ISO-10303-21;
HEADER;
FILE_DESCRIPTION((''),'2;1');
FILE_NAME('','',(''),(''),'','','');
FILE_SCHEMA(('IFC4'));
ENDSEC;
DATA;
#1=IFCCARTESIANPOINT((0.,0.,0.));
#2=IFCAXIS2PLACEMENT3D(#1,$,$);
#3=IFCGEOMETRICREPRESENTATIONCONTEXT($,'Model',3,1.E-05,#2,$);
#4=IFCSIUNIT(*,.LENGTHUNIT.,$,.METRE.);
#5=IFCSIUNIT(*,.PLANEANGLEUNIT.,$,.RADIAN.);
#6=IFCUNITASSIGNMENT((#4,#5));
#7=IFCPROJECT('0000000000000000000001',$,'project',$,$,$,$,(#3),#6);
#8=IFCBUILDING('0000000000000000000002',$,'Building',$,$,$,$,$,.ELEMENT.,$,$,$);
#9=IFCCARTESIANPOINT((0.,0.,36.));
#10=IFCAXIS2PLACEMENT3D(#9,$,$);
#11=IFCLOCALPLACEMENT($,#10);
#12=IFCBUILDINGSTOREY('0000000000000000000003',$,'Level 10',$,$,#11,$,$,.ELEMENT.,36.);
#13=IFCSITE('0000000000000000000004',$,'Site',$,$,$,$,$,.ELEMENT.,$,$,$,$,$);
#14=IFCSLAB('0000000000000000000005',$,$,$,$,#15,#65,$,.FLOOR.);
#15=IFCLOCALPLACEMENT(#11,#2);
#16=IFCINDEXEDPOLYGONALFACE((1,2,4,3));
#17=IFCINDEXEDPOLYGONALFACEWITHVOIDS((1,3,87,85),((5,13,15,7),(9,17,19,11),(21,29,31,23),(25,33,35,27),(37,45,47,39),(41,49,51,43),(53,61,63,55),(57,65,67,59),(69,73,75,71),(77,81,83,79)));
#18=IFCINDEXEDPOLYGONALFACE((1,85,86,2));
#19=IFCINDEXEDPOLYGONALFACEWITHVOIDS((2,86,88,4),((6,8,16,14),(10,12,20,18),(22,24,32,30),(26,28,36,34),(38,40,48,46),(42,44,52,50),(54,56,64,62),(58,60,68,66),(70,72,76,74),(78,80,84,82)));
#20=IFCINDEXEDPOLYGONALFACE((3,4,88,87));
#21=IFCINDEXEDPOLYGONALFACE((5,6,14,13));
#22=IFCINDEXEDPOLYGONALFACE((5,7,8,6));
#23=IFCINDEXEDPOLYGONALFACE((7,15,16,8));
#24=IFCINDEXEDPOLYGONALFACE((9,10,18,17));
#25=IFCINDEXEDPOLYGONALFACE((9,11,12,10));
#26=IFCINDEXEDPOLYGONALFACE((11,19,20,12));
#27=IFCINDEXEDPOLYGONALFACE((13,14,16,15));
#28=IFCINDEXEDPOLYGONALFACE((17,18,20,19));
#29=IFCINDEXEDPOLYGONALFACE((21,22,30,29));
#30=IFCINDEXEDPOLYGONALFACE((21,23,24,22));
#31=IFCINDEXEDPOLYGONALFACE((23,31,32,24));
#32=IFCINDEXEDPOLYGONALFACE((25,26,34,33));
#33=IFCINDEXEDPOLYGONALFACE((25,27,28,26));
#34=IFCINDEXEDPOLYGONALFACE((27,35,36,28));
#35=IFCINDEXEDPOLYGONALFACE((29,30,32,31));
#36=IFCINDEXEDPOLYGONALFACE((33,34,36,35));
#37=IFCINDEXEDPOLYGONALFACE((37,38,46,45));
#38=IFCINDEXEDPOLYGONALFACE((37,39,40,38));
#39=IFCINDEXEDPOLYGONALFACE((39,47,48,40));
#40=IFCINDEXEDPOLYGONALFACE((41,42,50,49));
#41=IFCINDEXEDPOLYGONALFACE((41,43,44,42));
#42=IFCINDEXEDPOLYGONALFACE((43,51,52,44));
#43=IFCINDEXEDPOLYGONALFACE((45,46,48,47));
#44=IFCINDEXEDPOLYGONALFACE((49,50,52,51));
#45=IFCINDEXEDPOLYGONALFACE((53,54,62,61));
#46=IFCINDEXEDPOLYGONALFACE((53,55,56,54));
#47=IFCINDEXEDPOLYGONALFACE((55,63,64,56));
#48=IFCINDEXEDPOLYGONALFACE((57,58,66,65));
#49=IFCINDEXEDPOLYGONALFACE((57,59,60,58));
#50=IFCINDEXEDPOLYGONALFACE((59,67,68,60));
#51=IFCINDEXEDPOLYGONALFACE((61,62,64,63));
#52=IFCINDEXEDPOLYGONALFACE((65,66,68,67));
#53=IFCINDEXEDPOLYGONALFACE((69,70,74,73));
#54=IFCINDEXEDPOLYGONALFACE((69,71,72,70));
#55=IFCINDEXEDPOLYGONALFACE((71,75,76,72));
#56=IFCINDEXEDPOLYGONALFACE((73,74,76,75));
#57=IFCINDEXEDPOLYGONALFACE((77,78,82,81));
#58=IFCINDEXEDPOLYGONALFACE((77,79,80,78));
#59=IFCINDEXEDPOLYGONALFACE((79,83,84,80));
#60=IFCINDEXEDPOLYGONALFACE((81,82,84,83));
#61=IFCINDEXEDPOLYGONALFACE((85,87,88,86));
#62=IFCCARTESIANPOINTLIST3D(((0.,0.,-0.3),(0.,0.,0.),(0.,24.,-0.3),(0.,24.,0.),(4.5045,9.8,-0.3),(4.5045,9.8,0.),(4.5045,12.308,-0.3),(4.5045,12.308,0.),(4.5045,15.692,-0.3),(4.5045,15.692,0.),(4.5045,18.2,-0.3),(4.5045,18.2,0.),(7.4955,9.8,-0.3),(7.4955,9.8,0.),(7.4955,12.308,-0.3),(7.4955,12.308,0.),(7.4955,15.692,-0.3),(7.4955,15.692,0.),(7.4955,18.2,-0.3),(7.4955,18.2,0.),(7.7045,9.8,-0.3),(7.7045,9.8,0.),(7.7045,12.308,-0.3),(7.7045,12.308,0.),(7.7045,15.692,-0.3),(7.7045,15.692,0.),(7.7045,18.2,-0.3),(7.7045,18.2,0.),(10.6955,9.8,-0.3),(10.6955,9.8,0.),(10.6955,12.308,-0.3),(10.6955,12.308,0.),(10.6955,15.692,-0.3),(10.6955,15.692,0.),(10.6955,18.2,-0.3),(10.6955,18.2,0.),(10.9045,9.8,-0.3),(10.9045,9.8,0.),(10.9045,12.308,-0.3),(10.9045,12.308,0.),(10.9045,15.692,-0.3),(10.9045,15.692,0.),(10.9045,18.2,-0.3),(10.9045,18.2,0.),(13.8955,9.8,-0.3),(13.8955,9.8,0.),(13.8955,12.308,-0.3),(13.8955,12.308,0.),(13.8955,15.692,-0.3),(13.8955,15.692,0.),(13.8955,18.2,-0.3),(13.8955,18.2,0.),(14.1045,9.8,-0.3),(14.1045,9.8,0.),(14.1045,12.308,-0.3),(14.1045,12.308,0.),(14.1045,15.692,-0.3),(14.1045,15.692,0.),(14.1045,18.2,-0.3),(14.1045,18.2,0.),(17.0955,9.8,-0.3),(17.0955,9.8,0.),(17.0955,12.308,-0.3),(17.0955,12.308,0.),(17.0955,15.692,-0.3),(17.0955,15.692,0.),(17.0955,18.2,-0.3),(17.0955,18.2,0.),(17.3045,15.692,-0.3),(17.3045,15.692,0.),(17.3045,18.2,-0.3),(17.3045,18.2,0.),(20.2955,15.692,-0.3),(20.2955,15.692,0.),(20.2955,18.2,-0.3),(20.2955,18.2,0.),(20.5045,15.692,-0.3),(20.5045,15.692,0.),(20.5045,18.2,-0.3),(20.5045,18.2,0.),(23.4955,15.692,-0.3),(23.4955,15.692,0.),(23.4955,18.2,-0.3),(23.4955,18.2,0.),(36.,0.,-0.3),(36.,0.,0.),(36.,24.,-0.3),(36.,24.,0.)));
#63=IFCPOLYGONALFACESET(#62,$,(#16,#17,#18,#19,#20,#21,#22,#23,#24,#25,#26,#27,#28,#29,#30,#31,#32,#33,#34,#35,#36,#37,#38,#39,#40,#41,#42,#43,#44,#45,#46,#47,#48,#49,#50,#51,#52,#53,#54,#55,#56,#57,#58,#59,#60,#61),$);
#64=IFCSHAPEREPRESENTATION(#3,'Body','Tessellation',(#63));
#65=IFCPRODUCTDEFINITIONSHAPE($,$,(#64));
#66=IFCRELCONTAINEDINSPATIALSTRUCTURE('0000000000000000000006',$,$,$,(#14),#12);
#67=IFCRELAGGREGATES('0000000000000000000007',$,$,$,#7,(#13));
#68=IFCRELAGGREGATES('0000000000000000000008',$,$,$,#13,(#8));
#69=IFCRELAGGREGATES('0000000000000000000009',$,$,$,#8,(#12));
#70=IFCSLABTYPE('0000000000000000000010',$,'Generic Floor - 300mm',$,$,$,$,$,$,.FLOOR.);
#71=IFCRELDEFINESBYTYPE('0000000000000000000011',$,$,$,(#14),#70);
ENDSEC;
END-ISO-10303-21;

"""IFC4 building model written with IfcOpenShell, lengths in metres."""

from ifc_helpers import new_model, si_unit, frame, origin, place, context, project, spatial, polyline, outline, extrude, type_object, element, save


model = new_model("IFC4")

# Units and contexts
model_context = context("Model", 3, precision=1e-05, world=origin())
ifc_project = project(units=[si_unit("LENGTHUNIT", "METRE"), si_unit("PLANEANGLEUNIT", "RADIAN")], contexts=[model_context])

# Site, building, storey
site = spatial("IfcSite", under=ifc_project, Name="Site", CompositionType="ELEMENT")
building = spatial("IfcBuilding", under=site, Name="Building", CompositionType="ELEMENT")
storey_placement = place(None, frame((0.0, 0.0, 36.0)))
storey = spatial("IfcBuildingStorey", under=building, at=storey_placement, Name="Level 10", CompositionType="ELEMENT", Elevation=36.0)

# Slab, openings
slab_type = type_object("IfcSlabType", Name="Generic Floor - 300mm", PredefinedType="FLOOR")
slab_placement = place(None, frame((0.0, 0.0, 36.0)))
slab = element("IfcSlab", 1, at=slab_placement, inside=storey, type_object=slab_type, PredefinedType="FLOOR", context=model_context, shape_type="SweptSolid", body=[
    extrude(outline(polyline([(0.0, 0.0), (36.0, 0.0), (36.0, 24.0), (0.0, 24.0), (0.0, 0.0)])), origin(), (0.0, 0.0, -1.0), 0.3),
])
opening_1_placement = place(None, frame((0.0, 0.0, 36.001)))
element("IfcOpeningElement", 2, at=opening_1_placement, cuts=slab, PredefinedType="OPENING", context=model_context, shape_type="SweptSolid", body=[
    extrude(outline(polyline([(4.5045, 9.8), (7.4955, 9.8), (7.4955, 12.308), (4.5045, 12.308), (4.5045, 9.8)])), origin(), (0.0, 0.0, -1.0), 0.302),
])
opening_2_placement = place(None, frame((0.0, 0.0, 36.001)))
element("IfcOpeningElement", 3, at=opening_2_placement, cuts=slab, PredefinedType="OPENING", context=model_context, shape_type="SweptSolid", body=[
    extrude(outline(polyline([(7.7045, 9.8), (10.6955, 9.8), (10.6955, 12.308), (7.7045, 12.308), (7.7045, 9.8)])), origin(), (0.0, 0.0, -1.0), 0.302),
])
opening_3_placement = place(None, frame((0.0, 0.0, 36.001)))
element("IfcOpeningElement", 4, at=opening_3_placement, cuts=slab, PredefinedType="OPENING", context=model_context, shape_type="SweptSolid", body=[
    extrude(outline(polyline([(10.9045, 9.8), (13.8955, 9.8), (13.8955, 12.308), (10.9045, 12.308), (10.9045, 9.8)])), origin(), (0.0, 0.0, -1.0), 0.302),
])
opening_4_placement = place(None, frame((0.0, 0.0, 36.001)))
element("IfcOpeningElement", 5, at=opening_4_placement, cuts=slab, PredefinedType="OPENING", context=model_context, shape_type="SweptSolid", body=[
    extrude(outline(polyline([(14.1045, 9.8), (17.0955, 9.8), (17.0955, 12.308), (14.1045, 12.308), (14.1045, 9.8)])), origin(), (0.0, 0.0, -1.0), 0.302),
])
opening_5_placement = place(None, frame((0.0, 0.0, 36.001)))
element("IfcOpeningElement", 6, at=opening_5_placement, cuts=slab, PredefinedType="OPENING", context=model_context, shape_type="SweptSolid", body=[
    extrude(outline(polyline([(7.4955, 18.2), (4.5045, 18.2), (4.5045, 15.692), (7.4955, 15.692), (7.4955, 18.2)])), origin(), (0.0, 0.0, -1.0), 0.302),
])
opening_6_placement = place(None, frame((0.0, 0.0, 36.001)))
element("IfcOpeningElement", 7, at=opening_6_placement, cuts=slab, PredefinedType="OPENING", context=model_context, shape_type="SweptSolid", body=[
    extrude(outline(polyline([(10.6955, 18.2), (7.7045, 18.2), (7.7045, 15.692), (10.6955, 15.692), (10.6955, 18.2)])), origin(), (0.0, 0.0, -1.0), 0.302),
])
opening_7_placement = place(None, frame((0.0, 0.0, 36.001)))
element("IfcOpeningElement", 8, at=opening_7_placement, cuts=slab, PredefinedType="OPENING", context=model_context, shape_type="SweptSolid", body=[
    extrude(outline(polyline([(13.8955, 18.2), (10.9045, 18.2), (10.9045, 15.692), (13.8955, 15.692), (13.8955, 18.2)])), origin(), (0.0, 0.0, -1.0), 0.302),
])
opening_8_placement = place(None, frame((0.0, 0.0, 36.001)))
element("IfcOpeningElement", 9, at=opening_8_placement, cuts=slab, PredefinedType="OPENING", context=model_context, shape_type="SweptSolid", body=[
    extrude(outline(polyline([(17.0955, 18.2), (14.1045, 18.2), (14.1045, 15.692), (17.0955, 15.692), (17.0955, 18.2)])), origin(), (0.0, 0.0, -1.0), 0.302),
])
opening_9_placement = place(None, frame((0.0, 0.0, 36.001)))
element("IfcOpeningElement", 10, at=opening_9_placement, cuts=slab, PredefinedType="OPENING", context=model_context, shape_type="SweptSolid", body=[
    extrude(outline(polyline([(20.2955, 18.2), (17.3045, 18.2), (17.3045, 15.692), (20.2955, 15.692), (20.2955, 18.2)])), origin(), (0.0, 0.0, -1.0), 0.302),
])
opening_10_placement = place(None, frame((0.0, 0.0, 36.001)))
element("IfcOpeningElement", 11, at=opening_10_placement, cuts=slab, PredefinedType="OPENING", context=model_context, shape_type="SweptSolid", body=[
    extrude(outline(polyline([(23.4955, 18.2), (20.5045, 18.2), (20.5045, 15.692), (23.4955, 15.692), (23.4955, 18.2)])), origin(), (0.0, 0.0, -1.0), 0.302),
])

save(model, "model.ifc")
